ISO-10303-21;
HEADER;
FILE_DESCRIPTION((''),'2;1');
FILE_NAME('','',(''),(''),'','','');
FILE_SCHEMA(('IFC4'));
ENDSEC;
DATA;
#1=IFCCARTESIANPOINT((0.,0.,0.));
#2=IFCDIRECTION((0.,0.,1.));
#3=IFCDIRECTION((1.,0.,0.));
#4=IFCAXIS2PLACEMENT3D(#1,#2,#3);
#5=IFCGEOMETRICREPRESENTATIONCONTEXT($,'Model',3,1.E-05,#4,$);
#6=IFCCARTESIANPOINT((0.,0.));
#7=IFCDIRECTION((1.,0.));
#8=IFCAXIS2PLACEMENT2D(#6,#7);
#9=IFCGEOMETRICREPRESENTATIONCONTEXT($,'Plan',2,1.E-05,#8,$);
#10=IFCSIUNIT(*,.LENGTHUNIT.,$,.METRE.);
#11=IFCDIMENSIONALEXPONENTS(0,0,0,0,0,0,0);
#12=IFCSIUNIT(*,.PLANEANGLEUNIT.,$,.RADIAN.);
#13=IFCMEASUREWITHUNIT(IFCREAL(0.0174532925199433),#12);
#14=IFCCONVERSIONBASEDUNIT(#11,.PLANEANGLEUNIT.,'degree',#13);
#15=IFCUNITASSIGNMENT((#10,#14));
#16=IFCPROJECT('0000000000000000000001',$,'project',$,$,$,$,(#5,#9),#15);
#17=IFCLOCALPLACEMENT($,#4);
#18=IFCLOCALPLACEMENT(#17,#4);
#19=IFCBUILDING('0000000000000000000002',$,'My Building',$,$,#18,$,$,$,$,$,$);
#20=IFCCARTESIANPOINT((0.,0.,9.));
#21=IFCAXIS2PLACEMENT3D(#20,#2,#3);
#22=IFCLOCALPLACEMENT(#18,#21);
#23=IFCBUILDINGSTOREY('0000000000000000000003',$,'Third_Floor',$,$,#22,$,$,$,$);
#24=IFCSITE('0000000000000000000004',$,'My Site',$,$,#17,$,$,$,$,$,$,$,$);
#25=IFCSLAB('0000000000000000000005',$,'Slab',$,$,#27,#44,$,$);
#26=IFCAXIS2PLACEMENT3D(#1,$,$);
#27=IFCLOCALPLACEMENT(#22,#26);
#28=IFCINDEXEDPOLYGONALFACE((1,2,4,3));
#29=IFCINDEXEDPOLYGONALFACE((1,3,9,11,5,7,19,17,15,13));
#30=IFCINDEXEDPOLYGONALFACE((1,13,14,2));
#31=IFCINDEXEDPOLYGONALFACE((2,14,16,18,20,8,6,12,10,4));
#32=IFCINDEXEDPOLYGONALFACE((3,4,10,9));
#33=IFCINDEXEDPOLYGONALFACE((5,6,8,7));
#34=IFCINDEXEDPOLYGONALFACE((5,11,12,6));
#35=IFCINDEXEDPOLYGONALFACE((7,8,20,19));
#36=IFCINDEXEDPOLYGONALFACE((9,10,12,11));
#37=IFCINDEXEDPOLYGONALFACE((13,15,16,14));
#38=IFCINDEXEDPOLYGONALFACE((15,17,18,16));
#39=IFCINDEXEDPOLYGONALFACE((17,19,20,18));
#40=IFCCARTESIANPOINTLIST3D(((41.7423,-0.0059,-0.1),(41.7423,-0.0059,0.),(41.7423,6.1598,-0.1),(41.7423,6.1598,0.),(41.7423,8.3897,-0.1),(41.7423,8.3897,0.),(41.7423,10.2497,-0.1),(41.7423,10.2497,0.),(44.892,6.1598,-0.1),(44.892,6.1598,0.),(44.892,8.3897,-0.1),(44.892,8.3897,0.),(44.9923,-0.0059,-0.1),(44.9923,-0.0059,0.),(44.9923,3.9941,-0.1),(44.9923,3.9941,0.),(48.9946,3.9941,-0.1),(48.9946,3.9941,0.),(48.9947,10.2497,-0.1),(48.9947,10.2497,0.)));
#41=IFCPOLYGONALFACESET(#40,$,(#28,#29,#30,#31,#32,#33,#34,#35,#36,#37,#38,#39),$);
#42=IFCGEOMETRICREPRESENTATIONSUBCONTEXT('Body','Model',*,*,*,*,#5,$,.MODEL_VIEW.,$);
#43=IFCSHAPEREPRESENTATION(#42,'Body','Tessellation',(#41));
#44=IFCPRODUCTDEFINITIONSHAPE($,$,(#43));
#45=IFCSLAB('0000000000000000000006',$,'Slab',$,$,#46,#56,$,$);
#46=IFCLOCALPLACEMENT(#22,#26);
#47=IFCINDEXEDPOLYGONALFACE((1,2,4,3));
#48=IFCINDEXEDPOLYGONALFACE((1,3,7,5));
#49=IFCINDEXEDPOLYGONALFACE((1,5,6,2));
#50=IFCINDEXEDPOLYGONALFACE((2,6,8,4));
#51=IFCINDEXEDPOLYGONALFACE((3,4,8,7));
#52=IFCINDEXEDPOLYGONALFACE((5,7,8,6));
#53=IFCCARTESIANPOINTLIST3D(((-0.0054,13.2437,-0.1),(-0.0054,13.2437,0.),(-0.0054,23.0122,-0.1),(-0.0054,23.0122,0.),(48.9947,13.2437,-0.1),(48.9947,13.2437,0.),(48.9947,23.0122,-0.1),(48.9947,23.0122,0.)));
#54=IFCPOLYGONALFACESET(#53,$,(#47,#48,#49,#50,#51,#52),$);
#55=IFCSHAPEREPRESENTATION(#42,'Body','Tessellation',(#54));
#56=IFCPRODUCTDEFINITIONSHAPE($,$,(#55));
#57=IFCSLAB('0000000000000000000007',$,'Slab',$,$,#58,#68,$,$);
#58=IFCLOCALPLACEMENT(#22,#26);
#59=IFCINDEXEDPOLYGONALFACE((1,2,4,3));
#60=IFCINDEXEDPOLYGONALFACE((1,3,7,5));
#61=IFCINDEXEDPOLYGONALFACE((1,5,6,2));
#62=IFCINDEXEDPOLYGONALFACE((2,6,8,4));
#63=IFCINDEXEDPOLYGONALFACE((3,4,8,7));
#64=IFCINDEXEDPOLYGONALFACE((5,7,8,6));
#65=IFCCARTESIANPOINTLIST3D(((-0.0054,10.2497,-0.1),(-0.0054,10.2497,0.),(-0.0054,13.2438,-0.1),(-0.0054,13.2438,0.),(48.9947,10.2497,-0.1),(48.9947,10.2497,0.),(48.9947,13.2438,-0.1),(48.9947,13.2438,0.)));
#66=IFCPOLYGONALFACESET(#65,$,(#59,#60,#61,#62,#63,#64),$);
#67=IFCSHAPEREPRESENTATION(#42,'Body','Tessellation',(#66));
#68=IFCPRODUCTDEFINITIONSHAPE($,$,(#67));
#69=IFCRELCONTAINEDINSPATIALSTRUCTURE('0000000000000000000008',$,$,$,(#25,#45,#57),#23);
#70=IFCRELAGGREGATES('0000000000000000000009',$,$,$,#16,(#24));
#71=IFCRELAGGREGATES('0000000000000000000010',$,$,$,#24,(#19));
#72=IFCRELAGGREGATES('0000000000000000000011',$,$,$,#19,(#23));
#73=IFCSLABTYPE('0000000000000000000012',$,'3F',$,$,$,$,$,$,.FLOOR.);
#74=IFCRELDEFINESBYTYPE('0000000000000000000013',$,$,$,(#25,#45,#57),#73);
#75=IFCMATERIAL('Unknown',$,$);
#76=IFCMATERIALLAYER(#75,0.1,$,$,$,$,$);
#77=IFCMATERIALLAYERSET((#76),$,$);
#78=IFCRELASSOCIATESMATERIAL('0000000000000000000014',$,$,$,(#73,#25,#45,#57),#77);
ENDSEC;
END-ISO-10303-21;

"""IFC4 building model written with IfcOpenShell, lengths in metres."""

from ifc_helpers import new_model, entity, si_unit, converted_unit, frame, origin_with_axes, origin_2d_with_axis, place, context, subcontext, project, spatial, indexed_curve, outline, extrude, material, layer, layer_set, layer_usage, type_object, element, save


model = new_model("IFC4")

# Units and contexts
model_context = context("Model", 3, precision=1e-05, world=origin_with_axes())
plan_context = context("Plan", 2, precision=1e-05, world=origin_2d_with_axis())
body_context = subcontext(model_context, "Body", "Model", "MODEL_VIEW")
ifc_project = project(units=[si_unit("LENGTHUNIT", "METRE"), converted_unit("PLANEANGLEUNIT", "degree", entity("IfcReal", 0.0174532925199433), si_unit("PLANEANGLEUNIT", "RADIAN"), dimensions=[0, 0, 0, 0, 0, 0, 0])], contexts=[model_context, plan_context])

# Site, building, storey
site_placement = place(None, origin_with_axes())
site = spatial("IfcSite", under=ifc_project, at=site_placement, Name="My Site")
building_placement = place(site_placement, origin_with_axes())
building = spatial("IfcBuilding", under=site, at=building_placement, Name="My Building")
storey_placement = place(building_placement, frame((0.0, 0.0, 9.0), z_axis=(0.0, 0.0, 1.0), x_axis=(1.0, 0.0, 0.0)))
storey = spatial("IfcBuildingStorey", under=building, at=storey_placement, Name="Third_Floor")

# Shared definitions
ifc_material = material(Name="Unknown")

# Slabs
ifc_layer = layer(ifc_material, 0.1)
ifc_layer_set = layer_set([ifc_layer])
ifc_layer_usage_1 = layer_usage(ifc_layer_set, "AXIS3", "POSITIVE", -0.1)
slab_type = type_object("IfcSlabType", Name="3F", PredefinedType="FLOOR", material=ifc_layer_set)
slab_1_placement = place(storey_placement, frame((48.9947, 10.2497, 0.0), z_axis=(0.0, 0.0, 1.0), x_axis=(1.0, 0.0, 0.0)))
element("IfcSlab", 1, at=slab_1_placement, inside=storey, type_object=slab_type, material=ifc_layer_usage_1, Name="Slab", context=body_context, shape_type="SweptSolid", body=[
    extrude(outline(indexed_curve([(0.0, 0.0), (-7.2524, 0.0), (-7.2524, -1.86), (-4.1027, -1.86), (-4.1027, -4.09), (-7.2524, -4.09), (-7.2524, -10.2556), (-4.0024, -10.2556), (-4.0024, -6.2557), (-0.0001, -6.2557), (0.0, 0.0)])), frame((0.0, 0.0, -0.1), z_axis=(0.0, 0.0, 1.0), x_axis=(1.0, 0.0, 0.0)), (0.0, 0.0, 1.0), 0.1),
])
ifc_layer_usage_2 = layer_usage(ifc_layer_set, "AXIS3", "POSITIVE", -0.1)
slab_2_placement = place(storey_placement, frame((48.9947, 23.0122, 0.0), z_axis=(0.0, 0.0, 1.0), x_axis=(1.0, 0.0, 0.0)))
element("IfcSlab", 2, at=slab_2_placement, inside=storey, type_object=slab_type, material=ifc_layer_usage_2, Name="Slab", context=body_context, shape_type="SweptSolid", body=[
    extrude(outline(indexed_curve([(0.0, 0.0), (-49.0001, 0.0), (-49.0001, -9.7685), (0.0, -9.7685), (0.0, 0.0)])), frame((0.0, 0.0, -0.1), z_axis=(0.0, 0.0, 1.0), x_axis=(1.0, 0.0, 0.0)), (0.0, 0.0, 1.0), 0.1),
])
ifc_layer_usage_3 = layer_usage(ifc_layer_set, "AXIS3", "POSITIVE", -0.1)
slab_3_placement = place(storey_placement, frame((48.9947, 13.2438, 0.0), z_axis=(0.0, 0.0, 1.0), x_axis=(1.0, 0.0, 0.0)))
element("IfcSlab", 3, at=slab_3_placement, inside=storey, type_object=slab_type, material=ifc_layer_usage_3, Name="Slab", context=body_context, shape_type="SweptSolid", body=[
    extrude(outline(indexed_curve([(0.0, 0.0), (-49.0001, 0.0), (-49.0001, -2.9941), (0.0, -2.9941), (0.0, 0.0)])), frame((0.0, 0.0, -0.1), z_axis=(0.0, 0.0, 1.0), x_axis=(1.0, 0.0, 0.0)), (0.0, 0.0, 1.0), 0.1),
])

save(model, "model.ifc")
